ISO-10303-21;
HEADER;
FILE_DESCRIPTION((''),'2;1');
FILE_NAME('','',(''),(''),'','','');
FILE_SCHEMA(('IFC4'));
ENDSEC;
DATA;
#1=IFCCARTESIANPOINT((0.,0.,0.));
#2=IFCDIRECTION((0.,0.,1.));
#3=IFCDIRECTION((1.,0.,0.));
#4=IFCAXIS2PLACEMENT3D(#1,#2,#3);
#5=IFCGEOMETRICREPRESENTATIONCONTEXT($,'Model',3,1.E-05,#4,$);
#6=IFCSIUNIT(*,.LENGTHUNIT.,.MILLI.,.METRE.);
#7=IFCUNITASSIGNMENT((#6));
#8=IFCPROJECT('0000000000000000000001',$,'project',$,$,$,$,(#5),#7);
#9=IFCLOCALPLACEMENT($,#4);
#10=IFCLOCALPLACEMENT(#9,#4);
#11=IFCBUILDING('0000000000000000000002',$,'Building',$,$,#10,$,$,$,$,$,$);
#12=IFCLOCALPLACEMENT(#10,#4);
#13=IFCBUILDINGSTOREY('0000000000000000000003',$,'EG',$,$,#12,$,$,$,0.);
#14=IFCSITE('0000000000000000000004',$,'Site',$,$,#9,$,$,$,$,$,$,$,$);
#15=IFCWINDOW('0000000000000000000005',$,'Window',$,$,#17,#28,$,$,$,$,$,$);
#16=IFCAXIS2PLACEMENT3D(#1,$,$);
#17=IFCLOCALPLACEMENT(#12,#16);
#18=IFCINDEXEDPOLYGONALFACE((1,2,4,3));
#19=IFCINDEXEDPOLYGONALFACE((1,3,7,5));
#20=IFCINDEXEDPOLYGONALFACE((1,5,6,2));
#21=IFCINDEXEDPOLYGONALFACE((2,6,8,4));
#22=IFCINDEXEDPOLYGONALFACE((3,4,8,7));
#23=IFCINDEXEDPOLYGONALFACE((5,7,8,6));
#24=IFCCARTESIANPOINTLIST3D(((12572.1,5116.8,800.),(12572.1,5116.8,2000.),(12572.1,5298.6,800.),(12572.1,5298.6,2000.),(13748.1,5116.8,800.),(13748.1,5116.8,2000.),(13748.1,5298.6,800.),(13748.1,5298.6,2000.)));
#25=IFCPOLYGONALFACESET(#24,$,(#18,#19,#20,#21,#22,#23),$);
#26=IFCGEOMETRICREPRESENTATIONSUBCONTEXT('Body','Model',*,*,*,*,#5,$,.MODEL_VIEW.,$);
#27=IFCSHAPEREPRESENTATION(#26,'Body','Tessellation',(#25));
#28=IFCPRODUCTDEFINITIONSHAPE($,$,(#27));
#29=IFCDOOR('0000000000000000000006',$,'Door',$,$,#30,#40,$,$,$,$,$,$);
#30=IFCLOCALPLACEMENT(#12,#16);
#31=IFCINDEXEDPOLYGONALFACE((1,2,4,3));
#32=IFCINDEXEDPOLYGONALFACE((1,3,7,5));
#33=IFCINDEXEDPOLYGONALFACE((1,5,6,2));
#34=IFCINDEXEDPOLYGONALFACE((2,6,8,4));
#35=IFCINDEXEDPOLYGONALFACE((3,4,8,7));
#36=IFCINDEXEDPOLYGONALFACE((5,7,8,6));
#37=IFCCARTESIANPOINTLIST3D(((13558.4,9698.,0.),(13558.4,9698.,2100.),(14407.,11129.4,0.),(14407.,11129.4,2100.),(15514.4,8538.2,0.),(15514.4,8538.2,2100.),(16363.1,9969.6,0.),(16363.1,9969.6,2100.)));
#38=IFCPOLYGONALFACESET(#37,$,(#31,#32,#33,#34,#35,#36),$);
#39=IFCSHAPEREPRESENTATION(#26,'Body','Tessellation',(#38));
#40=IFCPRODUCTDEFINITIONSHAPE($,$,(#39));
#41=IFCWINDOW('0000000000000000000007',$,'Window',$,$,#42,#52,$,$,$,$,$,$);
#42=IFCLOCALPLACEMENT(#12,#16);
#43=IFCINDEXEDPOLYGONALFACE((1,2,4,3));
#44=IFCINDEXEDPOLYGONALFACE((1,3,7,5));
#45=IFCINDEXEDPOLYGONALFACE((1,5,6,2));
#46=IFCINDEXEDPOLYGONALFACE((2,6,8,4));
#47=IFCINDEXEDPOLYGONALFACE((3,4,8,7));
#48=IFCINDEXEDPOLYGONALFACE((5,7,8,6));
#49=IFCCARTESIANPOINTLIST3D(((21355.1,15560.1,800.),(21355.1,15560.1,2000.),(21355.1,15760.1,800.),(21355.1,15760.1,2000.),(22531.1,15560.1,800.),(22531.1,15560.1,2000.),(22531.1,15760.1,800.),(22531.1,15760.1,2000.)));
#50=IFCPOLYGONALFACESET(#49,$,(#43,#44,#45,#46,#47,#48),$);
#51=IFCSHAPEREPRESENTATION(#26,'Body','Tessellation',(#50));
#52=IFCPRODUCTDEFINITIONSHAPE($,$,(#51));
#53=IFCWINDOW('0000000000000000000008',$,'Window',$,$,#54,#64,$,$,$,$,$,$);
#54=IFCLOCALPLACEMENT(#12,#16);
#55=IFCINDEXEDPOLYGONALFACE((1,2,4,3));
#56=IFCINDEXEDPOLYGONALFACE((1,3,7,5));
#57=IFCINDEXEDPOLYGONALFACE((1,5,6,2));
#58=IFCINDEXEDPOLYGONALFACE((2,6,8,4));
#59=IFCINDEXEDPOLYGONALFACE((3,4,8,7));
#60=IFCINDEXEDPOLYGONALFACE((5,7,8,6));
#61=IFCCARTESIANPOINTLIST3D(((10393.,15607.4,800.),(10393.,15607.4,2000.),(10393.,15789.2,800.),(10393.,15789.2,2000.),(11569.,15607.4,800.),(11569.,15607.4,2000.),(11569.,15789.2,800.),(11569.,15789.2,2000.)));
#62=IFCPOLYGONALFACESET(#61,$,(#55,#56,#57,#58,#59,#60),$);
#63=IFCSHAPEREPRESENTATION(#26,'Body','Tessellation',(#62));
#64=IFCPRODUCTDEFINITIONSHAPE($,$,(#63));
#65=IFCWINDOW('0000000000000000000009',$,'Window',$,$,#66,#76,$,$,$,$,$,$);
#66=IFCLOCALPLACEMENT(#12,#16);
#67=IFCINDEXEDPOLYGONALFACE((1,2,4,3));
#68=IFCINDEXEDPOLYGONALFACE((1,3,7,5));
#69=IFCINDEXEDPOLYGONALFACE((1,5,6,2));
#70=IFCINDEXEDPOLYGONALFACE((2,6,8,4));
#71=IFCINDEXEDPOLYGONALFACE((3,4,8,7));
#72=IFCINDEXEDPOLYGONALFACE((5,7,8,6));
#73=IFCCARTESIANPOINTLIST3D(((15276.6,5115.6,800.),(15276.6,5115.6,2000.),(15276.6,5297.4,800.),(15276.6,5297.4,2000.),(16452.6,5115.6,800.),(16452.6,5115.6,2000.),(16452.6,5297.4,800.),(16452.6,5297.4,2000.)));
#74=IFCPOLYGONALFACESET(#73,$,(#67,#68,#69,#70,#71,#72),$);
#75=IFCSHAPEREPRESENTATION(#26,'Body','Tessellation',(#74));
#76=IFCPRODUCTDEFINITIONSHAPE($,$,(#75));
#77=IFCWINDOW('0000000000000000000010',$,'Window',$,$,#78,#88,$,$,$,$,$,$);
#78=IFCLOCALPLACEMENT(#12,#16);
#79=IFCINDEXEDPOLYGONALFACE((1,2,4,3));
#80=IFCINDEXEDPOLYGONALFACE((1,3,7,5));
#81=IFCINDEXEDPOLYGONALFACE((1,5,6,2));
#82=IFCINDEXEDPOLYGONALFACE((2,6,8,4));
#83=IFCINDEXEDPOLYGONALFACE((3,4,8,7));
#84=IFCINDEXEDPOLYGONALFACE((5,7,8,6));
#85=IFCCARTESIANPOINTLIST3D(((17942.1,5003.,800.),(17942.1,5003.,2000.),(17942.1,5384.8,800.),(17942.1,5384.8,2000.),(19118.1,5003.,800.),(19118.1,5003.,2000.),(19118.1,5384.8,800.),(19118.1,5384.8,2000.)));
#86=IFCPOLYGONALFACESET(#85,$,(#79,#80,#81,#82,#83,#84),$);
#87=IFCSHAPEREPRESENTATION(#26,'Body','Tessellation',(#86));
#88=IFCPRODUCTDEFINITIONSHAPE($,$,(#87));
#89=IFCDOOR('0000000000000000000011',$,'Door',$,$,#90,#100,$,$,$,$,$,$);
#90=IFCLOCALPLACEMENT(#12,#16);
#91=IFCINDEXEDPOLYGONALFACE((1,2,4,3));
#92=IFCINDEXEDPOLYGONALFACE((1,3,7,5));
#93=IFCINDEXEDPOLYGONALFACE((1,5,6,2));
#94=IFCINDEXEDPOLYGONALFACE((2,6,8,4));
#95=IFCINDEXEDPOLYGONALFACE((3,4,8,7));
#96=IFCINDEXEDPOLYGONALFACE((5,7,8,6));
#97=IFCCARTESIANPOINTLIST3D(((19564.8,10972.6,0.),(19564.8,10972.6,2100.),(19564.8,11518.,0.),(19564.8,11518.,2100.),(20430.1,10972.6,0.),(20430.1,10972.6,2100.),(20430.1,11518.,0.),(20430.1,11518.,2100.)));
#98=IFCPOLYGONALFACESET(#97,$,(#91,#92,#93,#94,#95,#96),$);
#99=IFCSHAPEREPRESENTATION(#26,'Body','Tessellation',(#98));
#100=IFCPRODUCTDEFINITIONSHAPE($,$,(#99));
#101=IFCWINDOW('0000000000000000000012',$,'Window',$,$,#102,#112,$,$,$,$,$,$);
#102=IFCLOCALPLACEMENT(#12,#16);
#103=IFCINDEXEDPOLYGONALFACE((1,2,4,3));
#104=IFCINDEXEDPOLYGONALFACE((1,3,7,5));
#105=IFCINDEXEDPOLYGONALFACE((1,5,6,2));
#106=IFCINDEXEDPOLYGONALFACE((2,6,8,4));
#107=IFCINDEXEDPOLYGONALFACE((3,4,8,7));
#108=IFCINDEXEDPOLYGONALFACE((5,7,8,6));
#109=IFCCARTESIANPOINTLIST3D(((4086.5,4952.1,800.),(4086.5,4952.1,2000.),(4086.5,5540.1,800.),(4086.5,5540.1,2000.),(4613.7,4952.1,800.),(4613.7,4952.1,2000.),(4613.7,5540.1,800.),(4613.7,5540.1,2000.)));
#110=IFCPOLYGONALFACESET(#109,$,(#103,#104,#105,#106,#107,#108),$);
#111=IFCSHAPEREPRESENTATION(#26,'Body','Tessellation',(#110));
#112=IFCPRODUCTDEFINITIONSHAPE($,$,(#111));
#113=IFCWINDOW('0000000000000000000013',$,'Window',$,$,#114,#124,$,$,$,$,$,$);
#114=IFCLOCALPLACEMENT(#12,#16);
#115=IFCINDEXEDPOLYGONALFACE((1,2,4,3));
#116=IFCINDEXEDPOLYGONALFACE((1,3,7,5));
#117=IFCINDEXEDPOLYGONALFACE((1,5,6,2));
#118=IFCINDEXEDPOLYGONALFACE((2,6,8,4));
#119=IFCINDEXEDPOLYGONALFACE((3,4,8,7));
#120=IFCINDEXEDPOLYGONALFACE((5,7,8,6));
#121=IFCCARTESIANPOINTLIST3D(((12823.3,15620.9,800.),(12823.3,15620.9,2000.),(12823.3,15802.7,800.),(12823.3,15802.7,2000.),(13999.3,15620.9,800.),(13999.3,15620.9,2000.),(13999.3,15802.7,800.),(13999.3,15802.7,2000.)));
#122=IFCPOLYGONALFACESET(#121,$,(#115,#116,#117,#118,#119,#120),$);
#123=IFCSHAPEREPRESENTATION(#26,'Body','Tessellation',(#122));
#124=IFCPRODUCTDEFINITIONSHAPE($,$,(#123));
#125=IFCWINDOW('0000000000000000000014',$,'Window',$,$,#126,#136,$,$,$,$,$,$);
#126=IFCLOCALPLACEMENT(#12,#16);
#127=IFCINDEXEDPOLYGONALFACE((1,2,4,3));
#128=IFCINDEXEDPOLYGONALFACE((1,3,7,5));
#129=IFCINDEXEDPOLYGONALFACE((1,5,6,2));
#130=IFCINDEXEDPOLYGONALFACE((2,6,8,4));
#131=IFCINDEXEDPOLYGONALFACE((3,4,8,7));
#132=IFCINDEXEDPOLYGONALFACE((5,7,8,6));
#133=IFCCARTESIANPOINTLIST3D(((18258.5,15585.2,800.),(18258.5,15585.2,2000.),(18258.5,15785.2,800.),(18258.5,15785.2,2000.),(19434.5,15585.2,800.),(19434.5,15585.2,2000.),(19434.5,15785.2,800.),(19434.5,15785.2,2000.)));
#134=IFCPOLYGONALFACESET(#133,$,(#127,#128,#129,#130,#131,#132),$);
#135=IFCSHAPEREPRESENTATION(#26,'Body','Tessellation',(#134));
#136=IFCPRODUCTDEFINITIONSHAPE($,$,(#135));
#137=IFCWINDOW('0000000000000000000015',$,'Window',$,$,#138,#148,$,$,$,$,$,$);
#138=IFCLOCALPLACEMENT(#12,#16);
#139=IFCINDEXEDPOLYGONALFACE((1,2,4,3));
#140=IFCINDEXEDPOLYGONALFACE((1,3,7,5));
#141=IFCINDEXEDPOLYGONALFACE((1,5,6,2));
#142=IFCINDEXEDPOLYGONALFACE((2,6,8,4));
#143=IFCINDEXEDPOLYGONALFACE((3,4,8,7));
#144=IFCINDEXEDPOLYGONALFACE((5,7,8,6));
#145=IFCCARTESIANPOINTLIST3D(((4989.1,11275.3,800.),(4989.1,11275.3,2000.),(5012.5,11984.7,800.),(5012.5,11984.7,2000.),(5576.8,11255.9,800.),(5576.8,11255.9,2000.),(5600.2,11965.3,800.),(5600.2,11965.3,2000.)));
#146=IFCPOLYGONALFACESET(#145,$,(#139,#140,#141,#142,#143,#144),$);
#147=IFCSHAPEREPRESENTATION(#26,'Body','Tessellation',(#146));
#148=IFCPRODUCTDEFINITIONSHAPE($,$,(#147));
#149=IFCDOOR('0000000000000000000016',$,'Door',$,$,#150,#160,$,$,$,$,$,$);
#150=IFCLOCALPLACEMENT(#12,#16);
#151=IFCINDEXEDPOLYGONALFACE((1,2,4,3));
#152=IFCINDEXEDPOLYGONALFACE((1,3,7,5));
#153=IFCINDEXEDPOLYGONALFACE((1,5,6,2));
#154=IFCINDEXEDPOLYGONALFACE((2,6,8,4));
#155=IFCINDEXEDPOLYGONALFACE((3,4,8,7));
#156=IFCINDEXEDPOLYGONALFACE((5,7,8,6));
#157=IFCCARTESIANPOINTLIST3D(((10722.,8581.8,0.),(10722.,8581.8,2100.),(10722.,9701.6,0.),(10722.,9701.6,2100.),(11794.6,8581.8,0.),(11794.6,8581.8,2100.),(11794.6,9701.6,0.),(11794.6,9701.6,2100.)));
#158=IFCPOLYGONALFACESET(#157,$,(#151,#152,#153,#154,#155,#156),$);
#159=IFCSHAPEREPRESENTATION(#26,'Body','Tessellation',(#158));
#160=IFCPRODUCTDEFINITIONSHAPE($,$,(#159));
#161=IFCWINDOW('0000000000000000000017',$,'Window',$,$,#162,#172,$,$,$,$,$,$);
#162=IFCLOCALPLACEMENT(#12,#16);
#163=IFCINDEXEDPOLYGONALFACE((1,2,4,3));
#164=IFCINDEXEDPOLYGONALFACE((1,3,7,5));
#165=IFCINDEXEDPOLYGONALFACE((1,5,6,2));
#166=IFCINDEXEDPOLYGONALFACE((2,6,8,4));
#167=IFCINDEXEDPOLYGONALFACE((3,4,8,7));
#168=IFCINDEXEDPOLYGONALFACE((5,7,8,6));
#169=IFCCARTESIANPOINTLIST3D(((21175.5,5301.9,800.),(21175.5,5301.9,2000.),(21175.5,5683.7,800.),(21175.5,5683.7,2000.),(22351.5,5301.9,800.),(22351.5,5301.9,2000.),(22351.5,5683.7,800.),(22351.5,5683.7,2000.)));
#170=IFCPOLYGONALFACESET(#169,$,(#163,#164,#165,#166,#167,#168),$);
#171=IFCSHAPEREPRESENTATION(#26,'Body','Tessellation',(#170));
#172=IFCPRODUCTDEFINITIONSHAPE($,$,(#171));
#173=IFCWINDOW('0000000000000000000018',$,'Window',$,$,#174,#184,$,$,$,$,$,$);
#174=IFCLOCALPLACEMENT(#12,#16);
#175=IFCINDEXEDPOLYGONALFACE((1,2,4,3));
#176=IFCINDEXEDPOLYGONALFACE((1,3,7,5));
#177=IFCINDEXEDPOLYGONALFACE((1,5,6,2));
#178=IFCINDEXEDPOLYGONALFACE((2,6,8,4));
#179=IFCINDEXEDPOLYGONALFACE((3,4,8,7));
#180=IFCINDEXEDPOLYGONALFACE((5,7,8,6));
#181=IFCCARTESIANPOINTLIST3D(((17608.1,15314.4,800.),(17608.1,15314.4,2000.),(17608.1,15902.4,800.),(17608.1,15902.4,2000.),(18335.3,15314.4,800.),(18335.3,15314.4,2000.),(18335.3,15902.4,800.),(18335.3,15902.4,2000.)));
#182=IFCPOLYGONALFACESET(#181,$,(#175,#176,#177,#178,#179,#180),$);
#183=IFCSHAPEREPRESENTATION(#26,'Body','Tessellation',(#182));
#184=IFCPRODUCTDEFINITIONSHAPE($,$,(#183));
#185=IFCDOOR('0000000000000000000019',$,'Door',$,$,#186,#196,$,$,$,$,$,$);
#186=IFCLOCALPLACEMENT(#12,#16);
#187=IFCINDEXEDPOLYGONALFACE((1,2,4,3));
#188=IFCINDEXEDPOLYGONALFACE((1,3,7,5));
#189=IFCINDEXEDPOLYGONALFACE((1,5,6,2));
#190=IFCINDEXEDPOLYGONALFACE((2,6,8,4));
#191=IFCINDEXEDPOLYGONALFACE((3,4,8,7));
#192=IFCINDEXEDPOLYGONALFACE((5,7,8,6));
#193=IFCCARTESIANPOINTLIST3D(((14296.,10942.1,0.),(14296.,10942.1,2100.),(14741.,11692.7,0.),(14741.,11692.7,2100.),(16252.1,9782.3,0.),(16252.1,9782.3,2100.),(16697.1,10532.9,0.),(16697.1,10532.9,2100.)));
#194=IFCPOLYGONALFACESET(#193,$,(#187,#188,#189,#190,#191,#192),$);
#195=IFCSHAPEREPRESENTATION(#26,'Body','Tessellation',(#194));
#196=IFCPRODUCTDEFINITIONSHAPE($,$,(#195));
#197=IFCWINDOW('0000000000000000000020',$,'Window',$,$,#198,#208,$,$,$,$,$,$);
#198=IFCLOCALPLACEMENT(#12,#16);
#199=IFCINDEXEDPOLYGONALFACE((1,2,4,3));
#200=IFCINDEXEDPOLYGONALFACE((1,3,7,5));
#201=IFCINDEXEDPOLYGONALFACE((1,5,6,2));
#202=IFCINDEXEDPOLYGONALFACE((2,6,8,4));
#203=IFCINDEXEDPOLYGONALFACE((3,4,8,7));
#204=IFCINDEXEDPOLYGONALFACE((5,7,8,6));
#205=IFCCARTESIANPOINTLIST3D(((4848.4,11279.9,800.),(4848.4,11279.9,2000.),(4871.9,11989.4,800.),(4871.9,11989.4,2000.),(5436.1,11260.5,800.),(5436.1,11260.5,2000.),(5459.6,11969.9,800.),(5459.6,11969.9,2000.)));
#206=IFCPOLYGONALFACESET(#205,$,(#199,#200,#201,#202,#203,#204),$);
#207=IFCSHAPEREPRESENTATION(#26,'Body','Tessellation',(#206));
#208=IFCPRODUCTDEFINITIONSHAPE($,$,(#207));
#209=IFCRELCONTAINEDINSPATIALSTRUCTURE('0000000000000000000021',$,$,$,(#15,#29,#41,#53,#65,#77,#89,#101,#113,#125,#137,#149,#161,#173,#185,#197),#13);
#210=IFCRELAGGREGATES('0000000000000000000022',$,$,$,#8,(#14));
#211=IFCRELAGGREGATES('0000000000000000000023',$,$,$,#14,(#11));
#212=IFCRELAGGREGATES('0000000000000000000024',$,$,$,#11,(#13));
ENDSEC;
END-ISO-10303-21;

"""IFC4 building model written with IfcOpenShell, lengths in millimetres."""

from ifc_helpers import new_model, si_unit, frame, origin_with_axes, place, context, subcontext, project, spatial, rectangle, extrude, element, save


model = new_model("IFC4")

# Units and contexts
model_context = context("Model", 3, precision=1e-05, world=origin_with_axes())
body_context = subcontext(model_context, "Body", "Model", "MODEL_VIEW")
ifc_project = project(units=[si_unit("LENGTHUNIT", "METRE", prefix="MILLI")], contexts=[model_context])

# Site, building, storey
site_placement = place(None, origin_with_axes())
site = spatial("IfcSite", under=ifc_project, at=site_placement, Name="Site")
building_placement = place(site_placement, origin_with_axes())
building = spatial("IfcBuilding", under=site, at=building_placement, Name="Building")
storey_placement = place(building_placement, origin_with_axes())
storey = spatial("IfcBuildingStorey", under=building, at=storey_placement, Name="EG", Elevation=0.0)

# Window
window_1_placement = place(storey_placement, origin_with_axes())
element("IfcWindow", 1, at=window_1_placement, inside=storey, Name="Window", context=body_context, shape_type="SweptSolid", body=[
    extrude(rectangle(XDim=1176.0, YDim=181.8), frame((13160.1, 5207.7, 800.0), z_axis=(0.0, 0.0, 1.0), x_axis=(1.0, 0.0, 0.0)), (0.0, 0.0, 1.0), 1200.0),
])

# Door
door_1_placement = place(storey_placement, origin_with_axes())
element("IfcDoor", 2, at=door_1_placement, inside=storey, Name="Door", context=body_context, shape_type="SweptSolid", body=[
    extrude(rectangle(XDim=1664.0, YDim=2274.1), frame((14960.7, 9833.8, 0.0), z_axis=(0.0, 0.0, 1.0), x_axis=(-0.510011, -0.860168, 0.0)), (0.0, 0.0, 1.0), 2100.0),
])

# Windows
window_2_placement = place(storey_placement, origin_with_axes())
element("IfcWindow", 3, at=window_2_placement, inside=storey, Name="Window", context=body_context, shape_type="SweptSolid", body=[
    extrude(rectangle(XDim=1176.0, YDim=200.0), frame((21943.1, 15660.1, 800.0), z_axis=(0.0, 0.0, 1.0), x_axis=(1.0, 0.0, 0.0)), (0.0, 0.0, 1.0), 1200.0),
])
window_3_placement = place(storey_placement, origin_with_axes())
element("IfcWindow", 4, at=window_3_placement, inside=storey, Name="Window", context=body_context, shape_type="SweptSolid", body=[
    extrude(rectangle(XDim=1176.0, YDim=181.8), frame((10981.0, 15698.3, 800.0), z_axis=(0.0, 0.0, 1.0), x_axis=(1.0, 0.0, 0.0)), (0.0, 0.0, 1.0), 1200.0),
])
window_4_placement = place(storey_placement, origin_with_axes())
element("IfcWindow", 5, at=window_4_placement, inside=storey, Name="Window", context=body_context, shape_type="SweptSolid", body=[
    extrude(rectangle(XDim=1176.0, YDim=181.8), frame((15864.6, 5206.5, 800.0), z_axis=(0.0, 0.0, 1.0), x_axis=(1.0, 0.0, 0.0)), (0.0, 0.0, 1.0), 1200.0),
])
window_5_placement = place(storey_placement, origin_with_axes())
element("IfcWindow", 6, at=window_5_placement, inside=storey, Name="Window", context=body_context, shape_type="SweptSolid", body=[
    extrude(rectangle(XDim=1176.0, YDim=381.8), frame((18530.1, 5193.9, 800.0), z_axis=(0.0, 0.0, 1.0), x_axis=(1.0, 0.0, 0.0)), (0.0, 0.0, 1.0), 1200.0),
])

# Door
door_2_placement = place(storey_placement, origin_with_axes())
element("IfcDoor", 7, at=door_2_placement, inside=storey, Name="Door", context=body_context, shape_type="SweptSolid", body=[
    extrude(rectangle(XDim=865.3, YDim=545.4), frame((19997.4, 11245.3, 0.0), z_axis=(0.0, 0.0, 1.0), x_axis=(1.0, 0.0, 0.0)), (0.0, 0.0, 1.0), 2100.0),
])

# Windows
window_6_placement = place(storey_placement, origin_with_axes())
element("IfcWindow", 8, at=window_6_placement, inside=storey, Name="Window", context=body_context, shape_type="SweptSolid", body=[
    extrude(rectangle(XDim=588.0, YDim=527.2), frame((4350.1, 5246.1, 800.0), z_axis=(0.0, 0.0, 1.0), x_axis=(0.0, 1.0, 0.0)), (0.0, 0.0, 1.0), 1200.0),
])
window_7_placement = place(storey_placement, origin_with_axes())
element("IfcWindow", 9, at=window_7_placement, inside=storey, Name="Window", context=body_context, shape_type="SweptSolid", body=[
    extrude(rectangle(XDim=1176.0, YDim=181.8), frame((13411.3, 15711.8, 800.0), z_axis=(0.0, 0.0, 1.0), x_axis=(1.0, 0.0, 0.0)), (0.0, 0.0, 1.0), 1200.0),
])
window_8_placement = place(storey_placement, origin_with_axes())
element("IfcWindow", 10, at=window_8_placement, inside=storey, Name="Window", context=body_context, shape_type="SweptSolid", body=[
    extrude(rectangle(XDim=1176.0, YDim=200.0), frame((18846.5, 15685.2, 800.0), z_axis=(0.0, 0.0, 1.0), x_axis=(1.0, 0.0, 0.0)), (0.0, 0.0, 1.0), 1200.0),
])
window_9_placement = place(storey_placement, origin_with_axes())
element("IfcWindow", 11, at=window_9_placement, inside=storey, Name="Window", context=body_context, shape_type="SweptSolid", body=[
    extrude(rectangle(XDim=588.0, YDim=709.8), frame((5294.6, 11620.3, 800.0), z_axis=(0.0, 0.0, 1.0), x_axis=(0.999454, -0.03304, 0.0)), (0.0, 0.0, 1.0), 1200.0),
])

# Door
door_3_placement = place(storey_placement, origin_with_axes())
element("IfcDoor", 12, at=door_3_placement, inside=storey, Name="Door", context=body_context, shape_type="SweptSolid", body=[
    extrude(rectangle(XDim=1119.9, YDim=1072.6), frame((11258.3, 9141.7, 0.0), z_axis=(0.0, 0.0, 1.0), x_axis=(0.0, 1.0, 0.0)), (0.0, 0.0, 1.0), 2100.0),
])

# Windows
window_10_placement = place(storey_placement, origin_with_axes())
element("IfcWindow", 13, at=window_10_placement, inside=storey, Name="Window", context=body_context, shape_type="SweptSolid", body=[
    extrude(rectangle(XDim=1176.0, YDim=381.8), frame((21763.5, 5492.8, 800.0), z_axis=(0.0, 0.0, 1.0), x_axis=(1.0, 0.0, 0.0)), (0.0, 0.0, 1.0), 1200.0),
])
window_11_placement = place(storey_placement, origin_with_axes())
element("IfcWindow", 14, at=window_11_placement, inside=storey, Name="Window", context=body_context, shape_type="SweptSolid", body=[
    extrude(rectangle(XDim=588.0, YDim=727.2), frame((17971.7, 15608.4, 800.0), z_axis=(0.0, 0.0, 1.0), x_axis=(0.0, 1.0, 0.0)), (0.0, 0.0, 1.0), 1200.0),
])

# Door
door_4_placement = place(storey_placement, origin_with_axes())
element("IfcDoor", 15, at=door_4_placement, inside=storey, Name="Door", context=body_context, shape_type="SweptSolid", body=[
    extrude(rectangle(XDim=872.6, YDim=2274.1), frame((15496.6, 10737.5, 0.0), z_axis=(0.0, 0.0, 1.0), x_axis=(-0.510011, -0.860168, 0.0)), (0.0, 0.0, 1.0), 2100.0),
])

# Window
window_12_placement = place(storey_placement, origin_with_axes())
element("IfcWindow", 16, at=window_12_placement, inside=storey, Name="Window", context=body_context, shape_type="SweptSolid", body=[
    extrude(rectangle(XDim=588.0, YDim=709.8), frame((5154.0, 11624.9, 800.0), z_axis=(0.0, 0.0, 1.0), x_axis=(0.999454, -0.03304, 0.0)), (0.0, 0.0, 1.0), 1200.0),
])

save(model, "model.ifc")
